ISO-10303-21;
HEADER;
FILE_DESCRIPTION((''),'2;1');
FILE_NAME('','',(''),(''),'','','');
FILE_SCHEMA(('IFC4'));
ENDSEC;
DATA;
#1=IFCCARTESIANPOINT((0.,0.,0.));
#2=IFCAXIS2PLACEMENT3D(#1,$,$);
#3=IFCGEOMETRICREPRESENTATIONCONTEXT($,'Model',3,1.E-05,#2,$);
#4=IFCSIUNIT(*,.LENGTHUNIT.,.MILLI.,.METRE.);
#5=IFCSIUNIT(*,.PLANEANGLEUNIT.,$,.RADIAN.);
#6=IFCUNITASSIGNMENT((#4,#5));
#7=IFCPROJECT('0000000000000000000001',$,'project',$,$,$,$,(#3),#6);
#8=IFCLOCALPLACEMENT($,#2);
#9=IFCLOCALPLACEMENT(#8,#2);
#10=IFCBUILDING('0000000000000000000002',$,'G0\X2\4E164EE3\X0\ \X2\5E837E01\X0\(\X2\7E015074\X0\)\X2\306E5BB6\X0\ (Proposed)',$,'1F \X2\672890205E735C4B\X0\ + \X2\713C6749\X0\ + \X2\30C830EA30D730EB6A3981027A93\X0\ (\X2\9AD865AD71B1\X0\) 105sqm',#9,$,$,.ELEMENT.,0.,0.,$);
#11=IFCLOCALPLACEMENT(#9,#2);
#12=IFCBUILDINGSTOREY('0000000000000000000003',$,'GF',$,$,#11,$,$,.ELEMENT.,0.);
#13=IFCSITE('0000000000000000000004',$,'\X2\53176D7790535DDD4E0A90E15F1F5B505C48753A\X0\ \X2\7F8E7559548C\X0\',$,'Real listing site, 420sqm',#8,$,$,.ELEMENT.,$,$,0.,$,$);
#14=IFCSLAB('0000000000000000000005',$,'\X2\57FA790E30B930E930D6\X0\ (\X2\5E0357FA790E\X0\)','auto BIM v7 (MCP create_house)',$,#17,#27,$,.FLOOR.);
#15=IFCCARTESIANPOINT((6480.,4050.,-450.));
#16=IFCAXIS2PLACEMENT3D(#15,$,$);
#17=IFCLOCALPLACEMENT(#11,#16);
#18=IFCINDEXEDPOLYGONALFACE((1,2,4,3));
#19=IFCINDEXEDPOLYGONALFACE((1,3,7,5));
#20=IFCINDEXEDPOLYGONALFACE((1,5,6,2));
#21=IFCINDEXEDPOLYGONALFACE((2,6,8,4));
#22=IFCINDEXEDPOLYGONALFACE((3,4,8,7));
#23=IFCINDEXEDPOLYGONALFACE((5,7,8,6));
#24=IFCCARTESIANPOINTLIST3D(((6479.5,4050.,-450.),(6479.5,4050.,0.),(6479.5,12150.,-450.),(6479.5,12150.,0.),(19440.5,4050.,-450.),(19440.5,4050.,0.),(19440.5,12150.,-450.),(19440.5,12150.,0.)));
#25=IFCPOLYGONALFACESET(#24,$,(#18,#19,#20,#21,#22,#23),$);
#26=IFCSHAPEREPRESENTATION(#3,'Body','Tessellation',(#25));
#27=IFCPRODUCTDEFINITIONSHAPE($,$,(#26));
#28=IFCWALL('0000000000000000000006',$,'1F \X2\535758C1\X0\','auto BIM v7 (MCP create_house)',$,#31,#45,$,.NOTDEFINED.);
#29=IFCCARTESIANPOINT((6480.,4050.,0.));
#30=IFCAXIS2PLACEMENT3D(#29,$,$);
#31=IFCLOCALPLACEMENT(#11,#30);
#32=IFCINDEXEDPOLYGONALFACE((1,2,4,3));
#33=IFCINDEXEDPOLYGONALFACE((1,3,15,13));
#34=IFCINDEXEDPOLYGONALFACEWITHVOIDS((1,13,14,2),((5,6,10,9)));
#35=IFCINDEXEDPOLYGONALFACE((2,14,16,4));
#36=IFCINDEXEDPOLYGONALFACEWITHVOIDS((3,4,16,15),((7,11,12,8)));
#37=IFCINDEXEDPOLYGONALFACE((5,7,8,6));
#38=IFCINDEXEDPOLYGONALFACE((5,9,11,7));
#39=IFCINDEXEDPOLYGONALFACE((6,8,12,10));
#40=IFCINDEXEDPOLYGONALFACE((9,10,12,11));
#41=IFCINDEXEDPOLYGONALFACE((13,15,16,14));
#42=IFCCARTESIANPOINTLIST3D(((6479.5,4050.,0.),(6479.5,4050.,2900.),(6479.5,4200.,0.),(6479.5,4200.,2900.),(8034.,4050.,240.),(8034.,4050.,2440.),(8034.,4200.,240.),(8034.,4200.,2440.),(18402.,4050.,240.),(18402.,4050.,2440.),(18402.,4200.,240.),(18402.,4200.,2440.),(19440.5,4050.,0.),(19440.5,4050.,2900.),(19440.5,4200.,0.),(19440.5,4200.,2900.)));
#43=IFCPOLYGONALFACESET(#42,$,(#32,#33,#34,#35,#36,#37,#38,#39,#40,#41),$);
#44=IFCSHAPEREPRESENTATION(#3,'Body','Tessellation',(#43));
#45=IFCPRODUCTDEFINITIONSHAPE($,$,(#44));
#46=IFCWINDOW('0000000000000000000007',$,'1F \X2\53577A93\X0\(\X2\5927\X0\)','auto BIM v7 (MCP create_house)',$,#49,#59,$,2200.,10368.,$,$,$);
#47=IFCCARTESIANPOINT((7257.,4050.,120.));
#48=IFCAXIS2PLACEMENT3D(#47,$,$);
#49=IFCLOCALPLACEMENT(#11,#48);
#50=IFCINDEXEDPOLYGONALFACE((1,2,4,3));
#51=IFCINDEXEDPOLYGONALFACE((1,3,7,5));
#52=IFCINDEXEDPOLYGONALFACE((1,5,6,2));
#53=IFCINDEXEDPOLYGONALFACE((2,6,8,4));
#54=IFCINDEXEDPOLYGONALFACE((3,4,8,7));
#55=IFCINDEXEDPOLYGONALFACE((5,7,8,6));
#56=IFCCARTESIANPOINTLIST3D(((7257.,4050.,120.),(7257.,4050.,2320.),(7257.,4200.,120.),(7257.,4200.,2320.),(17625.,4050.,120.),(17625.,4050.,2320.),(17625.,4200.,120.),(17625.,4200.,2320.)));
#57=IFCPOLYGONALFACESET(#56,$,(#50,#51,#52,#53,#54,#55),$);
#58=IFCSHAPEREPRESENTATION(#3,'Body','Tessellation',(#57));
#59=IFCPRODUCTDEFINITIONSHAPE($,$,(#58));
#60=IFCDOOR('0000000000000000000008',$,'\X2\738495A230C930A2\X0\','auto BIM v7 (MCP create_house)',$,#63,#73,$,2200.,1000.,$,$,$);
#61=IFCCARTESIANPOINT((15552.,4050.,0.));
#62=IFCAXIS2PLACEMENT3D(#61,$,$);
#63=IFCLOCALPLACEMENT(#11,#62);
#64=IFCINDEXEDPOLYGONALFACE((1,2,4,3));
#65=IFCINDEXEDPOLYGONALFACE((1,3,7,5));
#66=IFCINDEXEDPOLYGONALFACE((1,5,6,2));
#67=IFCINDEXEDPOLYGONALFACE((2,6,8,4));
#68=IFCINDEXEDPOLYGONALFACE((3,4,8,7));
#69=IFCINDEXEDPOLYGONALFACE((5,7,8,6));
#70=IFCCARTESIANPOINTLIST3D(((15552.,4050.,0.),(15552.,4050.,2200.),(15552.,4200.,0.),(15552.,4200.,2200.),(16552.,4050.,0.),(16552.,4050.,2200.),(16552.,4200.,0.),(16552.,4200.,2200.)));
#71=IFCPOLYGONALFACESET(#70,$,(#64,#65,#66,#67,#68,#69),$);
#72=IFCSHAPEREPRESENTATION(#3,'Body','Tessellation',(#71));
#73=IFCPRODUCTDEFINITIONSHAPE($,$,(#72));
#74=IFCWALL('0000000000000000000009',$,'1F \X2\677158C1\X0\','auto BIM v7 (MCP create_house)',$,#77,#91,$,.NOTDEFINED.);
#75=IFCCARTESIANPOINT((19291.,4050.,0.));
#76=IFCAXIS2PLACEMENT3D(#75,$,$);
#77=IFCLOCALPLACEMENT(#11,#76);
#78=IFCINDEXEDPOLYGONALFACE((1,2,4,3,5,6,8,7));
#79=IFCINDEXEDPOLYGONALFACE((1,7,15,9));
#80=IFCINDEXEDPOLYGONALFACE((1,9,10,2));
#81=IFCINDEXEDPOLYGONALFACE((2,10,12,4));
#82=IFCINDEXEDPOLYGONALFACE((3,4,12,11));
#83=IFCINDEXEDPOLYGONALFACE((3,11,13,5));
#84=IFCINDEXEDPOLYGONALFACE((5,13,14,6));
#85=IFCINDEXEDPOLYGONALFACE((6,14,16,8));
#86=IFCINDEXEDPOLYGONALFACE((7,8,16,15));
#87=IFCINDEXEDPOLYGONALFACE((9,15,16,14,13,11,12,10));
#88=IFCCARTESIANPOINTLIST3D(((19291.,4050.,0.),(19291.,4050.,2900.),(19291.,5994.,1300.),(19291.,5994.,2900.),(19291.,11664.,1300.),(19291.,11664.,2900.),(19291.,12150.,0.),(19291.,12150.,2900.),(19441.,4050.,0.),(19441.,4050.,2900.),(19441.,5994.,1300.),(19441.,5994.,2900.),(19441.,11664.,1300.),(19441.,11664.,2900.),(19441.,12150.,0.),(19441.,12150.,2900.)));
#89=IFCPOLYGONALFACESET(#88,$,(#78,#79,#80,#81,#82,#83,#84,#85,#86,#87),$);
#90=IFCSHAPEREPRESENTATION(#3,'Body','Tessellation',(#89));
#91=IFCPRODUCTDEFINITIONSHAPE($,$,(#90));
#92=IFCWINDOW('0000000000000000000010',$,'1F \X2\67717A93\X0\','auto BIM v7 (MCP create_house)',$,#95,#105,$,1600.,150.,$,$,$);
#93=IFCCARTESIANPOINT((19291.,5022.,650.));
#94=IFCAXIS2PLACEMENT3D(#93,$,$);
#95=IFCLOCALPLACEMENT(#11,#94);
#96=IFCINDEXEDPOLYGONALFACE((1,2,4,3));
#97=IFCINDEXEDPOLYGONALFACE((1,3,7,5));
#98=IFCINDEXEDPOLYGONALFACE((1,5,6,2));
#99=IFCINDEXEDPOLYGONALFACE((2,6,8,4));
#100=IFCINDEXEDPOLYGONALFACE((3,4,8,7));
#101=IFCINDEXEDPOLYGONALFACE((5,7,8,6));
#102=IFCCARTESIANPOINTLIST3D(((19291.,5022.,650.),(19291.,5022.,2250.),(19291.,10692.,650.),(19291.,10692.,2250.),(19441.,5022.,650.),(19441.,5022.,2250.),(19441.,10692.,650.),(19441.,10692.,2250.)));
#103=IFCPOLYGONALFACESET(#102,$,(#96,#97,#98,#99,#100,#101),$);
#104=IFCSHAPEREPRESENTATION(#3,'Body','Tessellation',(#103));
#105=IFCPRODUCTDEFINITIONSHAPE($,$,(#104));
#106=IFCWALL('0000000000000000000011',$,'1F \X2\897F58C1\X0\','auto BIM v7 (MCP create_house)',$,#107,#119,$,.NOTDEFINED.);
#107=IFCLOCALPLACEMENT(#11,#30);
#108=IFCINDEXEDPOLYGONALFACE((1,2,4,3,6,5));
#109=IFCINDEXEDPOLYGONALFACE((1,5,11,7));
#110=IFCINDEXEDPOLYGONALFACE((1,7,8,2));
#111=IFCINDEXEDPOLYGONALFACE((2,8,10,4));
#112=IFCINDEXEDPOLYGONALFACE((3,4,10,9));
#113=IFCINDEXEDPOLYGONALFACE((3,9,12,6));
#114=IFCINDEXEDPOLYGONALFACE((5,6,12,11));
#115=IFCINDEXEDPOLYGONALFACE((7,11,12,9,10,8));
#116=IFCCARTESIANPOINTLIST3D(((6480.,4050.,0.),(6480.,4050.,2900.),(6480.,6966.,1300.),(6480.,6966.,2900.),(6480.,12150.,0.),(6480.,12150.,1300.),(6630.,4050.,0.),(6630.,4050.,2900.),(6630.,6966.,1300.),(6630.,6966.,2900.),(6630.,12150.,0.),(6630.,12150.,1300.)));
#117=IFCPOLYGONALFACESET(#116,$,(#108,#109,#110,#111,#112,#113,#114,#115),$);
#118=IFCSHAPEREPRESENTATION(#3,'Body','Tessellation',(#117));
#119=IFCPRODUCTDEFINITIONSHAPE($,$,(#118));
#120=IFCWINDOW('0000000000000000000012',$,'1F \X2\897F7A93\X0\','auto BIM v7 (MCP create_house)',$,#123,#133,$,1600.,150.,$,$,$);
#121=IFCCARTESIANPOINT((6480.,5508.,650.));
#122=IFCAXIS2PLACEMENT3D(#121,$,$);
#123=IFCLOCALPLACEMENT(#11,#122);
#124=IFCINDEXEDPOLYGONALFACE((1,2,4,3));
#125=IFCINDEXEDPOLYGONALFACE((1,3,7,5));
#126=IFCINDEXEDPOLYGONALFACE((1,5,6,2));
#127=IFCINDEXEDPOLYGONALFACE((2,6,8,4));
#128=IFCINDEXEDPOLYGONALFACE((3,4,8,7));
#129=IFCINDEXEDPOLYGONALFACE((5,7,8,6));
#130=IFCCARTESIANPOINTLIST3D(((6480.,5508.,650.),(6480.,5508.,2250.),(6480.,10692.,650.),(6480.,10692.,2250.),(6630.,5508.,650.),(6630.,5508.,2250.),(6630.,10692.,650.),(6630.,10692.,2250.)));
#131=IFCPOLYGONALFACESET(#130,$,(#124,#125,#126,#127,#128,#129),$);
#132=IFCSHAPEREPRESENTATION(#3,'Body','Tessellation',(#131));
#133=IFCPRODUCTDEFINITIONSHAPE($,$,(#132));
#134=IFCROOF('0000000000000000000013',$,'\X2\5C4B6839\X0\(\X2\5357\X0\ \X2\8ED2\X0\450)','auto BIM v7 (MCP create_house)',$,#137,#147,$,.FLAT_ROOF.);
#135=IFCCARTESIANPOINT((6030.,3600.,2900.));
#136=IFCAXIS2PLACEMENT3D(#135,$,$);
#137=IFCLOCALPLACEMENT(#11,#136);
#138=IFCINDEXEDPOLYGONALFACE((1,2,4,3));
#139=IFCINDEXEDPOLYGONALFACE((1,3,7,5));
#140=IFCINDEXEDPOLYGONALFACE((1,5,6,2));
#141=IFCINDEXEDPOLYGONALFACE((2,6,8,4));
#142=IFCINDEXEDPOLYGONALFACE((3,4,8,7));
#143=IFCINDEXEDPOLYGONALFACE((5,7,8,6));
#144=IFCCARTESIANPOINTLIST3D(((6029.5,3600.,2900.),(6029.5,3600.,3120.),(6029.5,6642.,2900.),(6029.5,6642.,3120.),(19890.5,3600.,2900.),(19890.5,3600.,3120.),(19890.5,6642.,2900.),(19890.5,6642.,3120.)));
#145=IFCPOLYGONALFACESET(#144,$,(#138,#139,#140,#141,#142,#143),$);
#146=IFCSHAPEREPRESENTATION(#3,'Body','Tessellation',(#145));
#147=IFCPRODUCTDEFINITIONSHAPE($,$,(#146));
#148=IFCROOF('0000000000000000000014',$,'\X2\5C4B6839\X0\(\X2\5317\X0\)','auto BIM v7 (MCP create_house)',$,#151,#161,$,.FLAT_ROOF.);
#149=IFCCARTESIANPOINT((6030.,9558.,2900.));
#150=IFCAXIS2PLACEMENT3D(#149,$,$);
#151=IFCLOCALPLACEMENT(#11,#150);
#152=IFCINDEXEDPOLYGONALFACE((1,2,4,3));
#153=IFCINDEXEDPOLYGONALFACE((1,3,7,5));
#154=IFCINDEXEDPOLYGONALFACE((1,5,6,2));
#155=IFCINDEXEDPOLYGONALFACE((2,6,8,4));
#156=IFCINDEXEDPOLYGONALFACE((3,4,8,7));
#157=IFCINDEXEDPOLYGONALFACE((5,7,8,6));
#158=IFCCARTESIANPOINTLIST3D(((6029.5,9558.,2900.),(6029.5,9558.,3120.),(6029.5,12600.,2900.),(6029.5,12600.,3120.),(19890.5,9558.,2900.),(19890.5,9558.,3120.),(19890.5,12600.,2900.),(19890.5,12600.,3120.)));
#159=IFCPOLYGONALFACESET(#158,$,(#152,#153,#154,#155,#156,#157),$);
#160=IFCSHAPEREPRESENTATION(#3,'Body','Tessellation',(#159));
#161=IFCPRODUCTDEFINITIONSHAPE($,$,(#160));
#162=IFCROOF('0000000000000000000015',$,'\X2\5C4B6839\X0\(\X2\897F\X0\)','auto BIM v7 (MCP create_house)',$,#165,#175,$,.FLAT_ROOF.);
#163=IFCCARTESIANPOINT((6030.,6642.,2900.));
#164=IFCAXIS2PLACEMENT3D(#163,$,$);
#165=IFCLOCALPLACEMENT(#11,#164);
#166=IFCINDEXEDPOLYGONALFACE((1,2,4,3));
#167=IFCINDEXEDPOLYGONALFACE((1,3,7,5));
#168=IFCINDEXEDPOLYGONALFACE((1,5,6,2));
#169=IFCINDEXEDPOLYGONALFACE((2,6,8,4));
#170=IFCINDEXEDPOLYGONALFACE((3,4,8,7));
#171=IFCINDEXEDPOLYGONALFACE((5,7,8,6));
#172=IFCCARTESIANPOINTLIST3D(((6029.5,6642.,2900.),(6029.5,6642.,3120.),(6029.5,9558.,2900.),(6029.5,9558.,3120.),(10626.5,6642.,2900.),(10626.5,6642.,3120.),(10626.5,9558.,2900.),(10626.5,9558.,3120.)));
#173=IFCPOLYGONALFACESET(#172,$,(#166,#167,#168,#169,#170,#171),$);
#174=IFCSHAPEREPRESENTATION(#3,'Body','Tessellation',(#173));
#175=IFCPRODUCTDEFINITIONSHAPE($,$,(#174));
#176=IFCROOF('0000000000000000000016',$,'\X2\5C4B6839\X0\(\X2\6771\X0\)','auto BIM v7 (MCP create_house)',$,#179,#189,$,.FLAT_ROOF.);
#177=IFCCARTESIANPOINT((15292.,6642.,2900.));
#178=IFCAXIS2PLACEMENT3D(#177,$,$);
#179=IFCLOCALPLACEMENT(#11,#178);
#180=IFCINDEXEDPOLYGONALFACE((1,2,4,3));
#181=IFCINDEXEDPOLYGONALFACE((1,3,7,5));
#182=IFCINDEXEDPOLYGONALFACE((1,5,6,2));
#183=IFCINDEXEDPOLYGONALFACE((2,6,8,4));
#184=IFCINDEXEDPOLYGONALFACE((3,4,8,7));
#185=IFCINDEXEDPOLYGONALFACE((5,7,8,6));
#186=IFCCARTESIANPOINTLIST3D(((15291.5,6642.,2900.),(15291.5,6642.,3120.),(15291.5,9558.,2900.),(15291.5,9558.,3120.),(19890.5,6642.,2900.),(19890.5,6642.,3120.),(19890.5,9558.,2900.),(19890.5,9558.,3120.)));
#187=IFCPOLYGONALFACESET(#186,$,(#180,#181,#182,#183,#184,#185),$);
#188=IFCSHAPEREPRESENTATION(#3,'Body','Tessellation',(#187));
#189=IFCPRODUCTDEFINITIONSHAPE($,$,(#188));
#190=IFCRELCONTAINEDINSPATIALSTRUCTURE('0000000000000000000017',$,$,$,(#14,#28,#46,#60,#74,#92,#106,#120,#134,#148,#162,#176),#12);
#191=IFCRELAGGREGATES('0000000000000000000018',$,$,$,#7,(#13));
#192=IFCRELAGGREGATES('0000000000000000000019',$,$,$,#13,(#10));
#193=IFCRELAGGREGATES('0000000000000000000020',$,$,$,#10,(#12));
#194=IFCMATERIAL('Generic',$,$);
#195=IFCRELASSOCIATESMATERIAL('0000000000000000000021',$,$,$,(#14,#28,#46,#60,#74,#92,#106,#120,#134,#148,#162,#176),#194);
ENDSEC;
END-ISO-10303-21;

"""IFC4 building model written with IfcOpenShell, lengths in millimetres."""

from ifc_helpers import new_model, si_unit, frame, frame_2d, origin, place, context, project, spatial, rectangle, extrude, material, element, fill, save


model = new_model("IFC4")

# Units and contexts
model_context = context("Model", 3, precision=1e-05, world=origin())
ifc_project = project(units=[si_unit("LENGTHUNIT", "METRE", prefix="MILLI"), si_unit("PLANEANGLEUNIT", "RADIAN")], contexts=[model_context])

# Site, building, storey
site_placement = place(None, origin())
site = spatial("IfcSite", under=ifc_project, at=site_placement, Name="北海道川上郡弟子屈町 美留和", ObjectType="Real listing site, 420sqm", CompositionType="ELEMENT", RefElevation=0.0)
building_placement = place(site_placement, origin())
building = spatial("IfcBuilding", under=site, at=building_placement, Name="G0世代 広縁(縁側)の家 (Proposed)", ObjectType="1F 木造平屋 + 焼杉 + トリプル樹脂窓 (高断熱) 105sqm", CompositionType="ELEMENT", ElevationOfRefHeight=0.0, ElevationOfTerrain=0.0)
storey_placement = place(building_placement, origin())
storey = spatial("IfcBuildingStorey", under=building, at=storey_placement, Name="GF", CompositionType="ELEMENT", Elevation=0.0)

# Slab
ifc_material = material(Name="Generic")
slab_1_placement = place(storey_placement, frame((6480.0, 4050.0, -450.0)))
element("IfcSlab", 1, at=slab_1_placement, inside=storey, material=ifc_material, Name="基礎スラブ (布基礎)", Description="auto BIM v7 (MCP create_house)", PredefinedType="FLOOR", context=model_context, shape_type="SweptSolid", body=[
    extrude(rectangle(XDim=12961.0, YDim=8100.0, at=frame_2d((6480.0, 4050.0))), frame((6480.0, 4050.0, -450.0)), (0.0, 0.0, 1.0), 450.0),
])

# Wall, openings, window, door
wall_1_placement = place(storey_placement, frame((6480.0, 4050.0, 0.0)))
wall_1 = element("IfcWall", 2, at=wall_1_placement, inside=storey, material=ifc_material, Name="1F 南壁", Description="auto BIM v7 (MCP create_house)", PredefinedType="NOTDEFINED", context=model_context, shape_type="SweptSolid", body=[
    extrude(rectangle(XDim=12961.0, YDim=150.0, at=frame_2d((6480.0, 75.0))), frame((6480.0, 4050.0, 0.0)), (0.0, 0.0, 1.0), 2900.0),
])
opening_1_placement = place(storey_placement, frame((7257.0, 4050.0, 120.0)))
opening_1 = element("IfcOpeningElement", 3, at=opening_1_placement, cuts=wall_1, PredefinedType="NOTDEFINED", context=model_context, shape_type="SweptSolid", body=[
    extrude(rectangle(XDim=10368.0, YDim=150.0, at=frame_2d((5184.0, 75.0))), frame((7257.0, 4050.0, 120.0)), (0.0, 0.0, 1.0), 2200.0),
])
opening_2_placement = place(storey_placement, frame((15552.0, 4050.0, 0.0)))
opening_2 = element("IfcOpeningElement", 4, at=opening_2_placement, cuts=wall_1, PredefinedType="NOTDEFINED", context=model_context, shape_type="SweptSolid", body=[
    extrude(rectangle(XDim=1000.0, YDim=150.0, at=frame_2d((500.0, 75.0))), frame((15552.0, 4050.0, 0.0)), (0.0, 0.0, 1.0), 2200.0),
])
window_1_placement = place(storey_placement, frame((7257.0, 4050.0, 120.0)))
window_1 = element("IfcWindow", 5, at=window_1_placement, inside=storey, material=ifc_material, Name="1F 南窓(大)", Description="auto BIM v7 (MCP create_house)", OverallHeight=2200.0, OverallWidth=10368.0, context=model_context, shape_type="SweptSolid", body=[
    extrude(rectangle(XDim=10368.0, YDim=150.0, at=frame_2d((5184.0, 75.0))), frame((7257.0, 4050.0, 120.0)), (0.0, 0.0, 1.0), 2200.0),
])
fill(opening_1, window_1)
door_placement = place(storey_placement, frame((15552.0, 4050.0, 0.0)))
door = element("IfcDoor", 6, at=door_placement, inside=storey, material=ifc_material, Name="玄関ドア", Description="auto BIM v7 (MCP create_house)", OverallHeight=2200.0, OverallWidth=1000.0, context=model_context, shape_type="SweptSolid", body=[
    extrude(rectangle(XDim=1000.0, YDim=150.0, at=frame_2d((500.0, 75.0))), frame((15552.0, 4050.0, 0.0)), (0.0, 0.0, 1.0), 2200.0),
])
fill(opening_2, door)

# Walls, openings, windows
wall_2_placement = place(storey_placement, frame((19291.0, 4050.0, 0.0)))
wall_2 = element("IfcWall", 7, at=wall_2_placement, inside=storey, material=ifc_material, Name="1F 東壁", Description="auto BIM v7 (MCP create_house)", PredefinedType="NOTDEFINED", context=model_context, shape_type="SweptSolid", body=[
    extrude(rectangle(XDim=150.0, YDim=8100.0, at=frame_2d((75.0, 4050.0))), frame((19291.0, 4050.0, 0.0)), (0.0, 0.0, 1.0), 2900.0),
])
opening_3_placement = place(storey_placement, frame((19291.0, 5022.0, 650.0)))
opening_3 = element("IfcOpeningElement", 8, at=opening_3_placement, cuts=wall_2, PredefinedType="NOTDEFINED", context=model_context, shape_type="SweptSolid", body=[
    extrude(rectangle(XDim=150.0, YDim=5670.0, at=frame_2d((75.0, 2835.0))), frame((19291.0, 5022.0, 650.0)), (0.0, 0.0, 1.0), 1600.0),
])
window_2_placement = place(storey_placement, frame((19291.0, 5022.0, 650.0)))
window_2 = element("IfcWindow", 9, at=window_2_placement, inside=storey, material=ifc_material, Name="1F 東窓", Description="auto BIM v7 (MCP create_house)", OverallHeight=1600.0, OverallWidth=150.0, context=model_context, shape_type="SweptSolid", body=[
    extrude(rectangle(XDim=150.0, YDim=5670.0, at=frame_2d((75.0, 2835.0))), frame((19291.0, 5022.0, 650.0)), (0.0, 0.0, 1.0), 1600.0),
])
fill(opening_3, window_2)
wall_3_placement = place(storey_placement, frame((6480.0, 4050.0, 0.0)))
wall_3 = element("IfcWall", 10, at=wall_3_placement, inside=storey, material=ifc_material, Name="1F 西壁", Description="auto BIM v7 (MCP create_house)", PredefinedType="NOTDEFINED", context=model_context, shape_type="SweptSolid", body=[
    extrude(rectangle(XDim=150.0, YDim=8100.0, at=frame_2d((75.0, 4050.0))), frame((6480.0, 4050.0, 0.0)), (0.0, 0.0, 1.0), 2900.0),
])
opening_4_placement = place(storey_placement, frame((6480.0, 5508.0, 650.0)))
opening_4 = element("IfcOpeningElement", 11, at=opening_4_placement, cuts=wall_3, PredefinedType="NOTDEFINED", context=model_context, shape_type="SweptSolid", body=[
    extrude(rectangle(XDim=150.0, YDim=5184.0, at=frame_2d((75.0, 2592.0))), frame((6480.0, 5508.0, 650.0)), (0.0, 0.0, 1.0), 1600.0),
])
window_3_placement = place(storey_placement, frame((6480.0, 5508.0, 650.0)))
window_3 = element("IfcWindow", 12, at=window_3_placement, inside=storey, material=ifc_material, Name="1F 西窓", Description="auto BIM v7 (MCP create_house)", OverallHeight=1600.0, OverallWidth=150.0, context=model_context, shape_type="SweptSolid", body=[
    extrude(rectangle(XDim=150.0, YDim=5184.0, at=frame_2d((75.0, 2592.0))), frame((6480.0, 5508.0, 650.0)), (0.0, 0.0, 1.0), 1600.0),
])
fill(opening_4, window_3)

# Roofs
roof_1_placement = place(storey_placement, frame((6030.0, 3600.0, 2900.0)))
element("IfcRoof", 13, at=roof_1_placement, inside=storey, material=ifc_material, Name="屋根(南 軒450)", Description="auto BIM v7 (MCP create_house)", PredefinedType="FLAT_ROOF", context=model_context, shape_type="SweptSolid", body=[
    extrude(rectangle(XDim=13861.0, YDim=3042.0, at=frame_2d((6930.0, 1521.0))), frame((6030.0, 3600.0, 2900.0)), (0.0, 0.0, 1.0), 220.0),
])
roof_2_placement = place(storey_placement, frame((6030.0, 9558.0, 2900.0)))
element("IfcRoof", 14, at=roof_2_placement, inside=storey, material=ifc_material, Name="屋根(北)", Description="auto BIM v7 (MCP create_house)", PredefinedType="FLAT_ROOF", context=model_context, shape_type="SweptSolid", body=[
    extrude(rectangle(XDim=13861.0, YDim=3042.0, at=frame_2d((6930.0, 1521.0))), frame((6030.0, 9558.0, 2900.0)), (0.0, 0.0, 1.0), 220.0),
])
roof_3_placement = place(storey_placement, frame((6030.0, 6642.0, 2900.0)))
element("IfcRoof", 15, at=roof_3_placement, inside=storey, material=ifc_material, Name="屋根(西)", Description="auto BIM v7 (MCP create_house)", PredefinedType="FLAT_ROOF", context=model_context, shape_type="SweptSolid", body=[
    extrude(rectangle(XDim=4597.0, YDim=2916.0, at=frame_2d((2298.0, 1458.0))), frame((6030.0, 6642.0, 2900.0)), (0.0, 0.0, 1.0), 220.0),
])
roof_4_placement = place(storey_placement, frame((15292.0, 6642.0, 2900.0)))
element("IfcRoof", 16, at=roof_4_placement, inside=storey, material=ifc_material, Name="屋根(東)", Description="auto BIM v7 (MCP create_house)", PredefinedType="FLAT_ROOF", context=model_context, shape_type="SweptSolid", body=[
    extrude(rectangle(XDim=4599.0, YDim=2916.0, at=frame_2d((2299.0, 1458.0))), frame((15292.0, 6642.0, 2900.0)), (0.0, 0.0, 1.0), 220.0),
])

save(model, "model.ifc")
